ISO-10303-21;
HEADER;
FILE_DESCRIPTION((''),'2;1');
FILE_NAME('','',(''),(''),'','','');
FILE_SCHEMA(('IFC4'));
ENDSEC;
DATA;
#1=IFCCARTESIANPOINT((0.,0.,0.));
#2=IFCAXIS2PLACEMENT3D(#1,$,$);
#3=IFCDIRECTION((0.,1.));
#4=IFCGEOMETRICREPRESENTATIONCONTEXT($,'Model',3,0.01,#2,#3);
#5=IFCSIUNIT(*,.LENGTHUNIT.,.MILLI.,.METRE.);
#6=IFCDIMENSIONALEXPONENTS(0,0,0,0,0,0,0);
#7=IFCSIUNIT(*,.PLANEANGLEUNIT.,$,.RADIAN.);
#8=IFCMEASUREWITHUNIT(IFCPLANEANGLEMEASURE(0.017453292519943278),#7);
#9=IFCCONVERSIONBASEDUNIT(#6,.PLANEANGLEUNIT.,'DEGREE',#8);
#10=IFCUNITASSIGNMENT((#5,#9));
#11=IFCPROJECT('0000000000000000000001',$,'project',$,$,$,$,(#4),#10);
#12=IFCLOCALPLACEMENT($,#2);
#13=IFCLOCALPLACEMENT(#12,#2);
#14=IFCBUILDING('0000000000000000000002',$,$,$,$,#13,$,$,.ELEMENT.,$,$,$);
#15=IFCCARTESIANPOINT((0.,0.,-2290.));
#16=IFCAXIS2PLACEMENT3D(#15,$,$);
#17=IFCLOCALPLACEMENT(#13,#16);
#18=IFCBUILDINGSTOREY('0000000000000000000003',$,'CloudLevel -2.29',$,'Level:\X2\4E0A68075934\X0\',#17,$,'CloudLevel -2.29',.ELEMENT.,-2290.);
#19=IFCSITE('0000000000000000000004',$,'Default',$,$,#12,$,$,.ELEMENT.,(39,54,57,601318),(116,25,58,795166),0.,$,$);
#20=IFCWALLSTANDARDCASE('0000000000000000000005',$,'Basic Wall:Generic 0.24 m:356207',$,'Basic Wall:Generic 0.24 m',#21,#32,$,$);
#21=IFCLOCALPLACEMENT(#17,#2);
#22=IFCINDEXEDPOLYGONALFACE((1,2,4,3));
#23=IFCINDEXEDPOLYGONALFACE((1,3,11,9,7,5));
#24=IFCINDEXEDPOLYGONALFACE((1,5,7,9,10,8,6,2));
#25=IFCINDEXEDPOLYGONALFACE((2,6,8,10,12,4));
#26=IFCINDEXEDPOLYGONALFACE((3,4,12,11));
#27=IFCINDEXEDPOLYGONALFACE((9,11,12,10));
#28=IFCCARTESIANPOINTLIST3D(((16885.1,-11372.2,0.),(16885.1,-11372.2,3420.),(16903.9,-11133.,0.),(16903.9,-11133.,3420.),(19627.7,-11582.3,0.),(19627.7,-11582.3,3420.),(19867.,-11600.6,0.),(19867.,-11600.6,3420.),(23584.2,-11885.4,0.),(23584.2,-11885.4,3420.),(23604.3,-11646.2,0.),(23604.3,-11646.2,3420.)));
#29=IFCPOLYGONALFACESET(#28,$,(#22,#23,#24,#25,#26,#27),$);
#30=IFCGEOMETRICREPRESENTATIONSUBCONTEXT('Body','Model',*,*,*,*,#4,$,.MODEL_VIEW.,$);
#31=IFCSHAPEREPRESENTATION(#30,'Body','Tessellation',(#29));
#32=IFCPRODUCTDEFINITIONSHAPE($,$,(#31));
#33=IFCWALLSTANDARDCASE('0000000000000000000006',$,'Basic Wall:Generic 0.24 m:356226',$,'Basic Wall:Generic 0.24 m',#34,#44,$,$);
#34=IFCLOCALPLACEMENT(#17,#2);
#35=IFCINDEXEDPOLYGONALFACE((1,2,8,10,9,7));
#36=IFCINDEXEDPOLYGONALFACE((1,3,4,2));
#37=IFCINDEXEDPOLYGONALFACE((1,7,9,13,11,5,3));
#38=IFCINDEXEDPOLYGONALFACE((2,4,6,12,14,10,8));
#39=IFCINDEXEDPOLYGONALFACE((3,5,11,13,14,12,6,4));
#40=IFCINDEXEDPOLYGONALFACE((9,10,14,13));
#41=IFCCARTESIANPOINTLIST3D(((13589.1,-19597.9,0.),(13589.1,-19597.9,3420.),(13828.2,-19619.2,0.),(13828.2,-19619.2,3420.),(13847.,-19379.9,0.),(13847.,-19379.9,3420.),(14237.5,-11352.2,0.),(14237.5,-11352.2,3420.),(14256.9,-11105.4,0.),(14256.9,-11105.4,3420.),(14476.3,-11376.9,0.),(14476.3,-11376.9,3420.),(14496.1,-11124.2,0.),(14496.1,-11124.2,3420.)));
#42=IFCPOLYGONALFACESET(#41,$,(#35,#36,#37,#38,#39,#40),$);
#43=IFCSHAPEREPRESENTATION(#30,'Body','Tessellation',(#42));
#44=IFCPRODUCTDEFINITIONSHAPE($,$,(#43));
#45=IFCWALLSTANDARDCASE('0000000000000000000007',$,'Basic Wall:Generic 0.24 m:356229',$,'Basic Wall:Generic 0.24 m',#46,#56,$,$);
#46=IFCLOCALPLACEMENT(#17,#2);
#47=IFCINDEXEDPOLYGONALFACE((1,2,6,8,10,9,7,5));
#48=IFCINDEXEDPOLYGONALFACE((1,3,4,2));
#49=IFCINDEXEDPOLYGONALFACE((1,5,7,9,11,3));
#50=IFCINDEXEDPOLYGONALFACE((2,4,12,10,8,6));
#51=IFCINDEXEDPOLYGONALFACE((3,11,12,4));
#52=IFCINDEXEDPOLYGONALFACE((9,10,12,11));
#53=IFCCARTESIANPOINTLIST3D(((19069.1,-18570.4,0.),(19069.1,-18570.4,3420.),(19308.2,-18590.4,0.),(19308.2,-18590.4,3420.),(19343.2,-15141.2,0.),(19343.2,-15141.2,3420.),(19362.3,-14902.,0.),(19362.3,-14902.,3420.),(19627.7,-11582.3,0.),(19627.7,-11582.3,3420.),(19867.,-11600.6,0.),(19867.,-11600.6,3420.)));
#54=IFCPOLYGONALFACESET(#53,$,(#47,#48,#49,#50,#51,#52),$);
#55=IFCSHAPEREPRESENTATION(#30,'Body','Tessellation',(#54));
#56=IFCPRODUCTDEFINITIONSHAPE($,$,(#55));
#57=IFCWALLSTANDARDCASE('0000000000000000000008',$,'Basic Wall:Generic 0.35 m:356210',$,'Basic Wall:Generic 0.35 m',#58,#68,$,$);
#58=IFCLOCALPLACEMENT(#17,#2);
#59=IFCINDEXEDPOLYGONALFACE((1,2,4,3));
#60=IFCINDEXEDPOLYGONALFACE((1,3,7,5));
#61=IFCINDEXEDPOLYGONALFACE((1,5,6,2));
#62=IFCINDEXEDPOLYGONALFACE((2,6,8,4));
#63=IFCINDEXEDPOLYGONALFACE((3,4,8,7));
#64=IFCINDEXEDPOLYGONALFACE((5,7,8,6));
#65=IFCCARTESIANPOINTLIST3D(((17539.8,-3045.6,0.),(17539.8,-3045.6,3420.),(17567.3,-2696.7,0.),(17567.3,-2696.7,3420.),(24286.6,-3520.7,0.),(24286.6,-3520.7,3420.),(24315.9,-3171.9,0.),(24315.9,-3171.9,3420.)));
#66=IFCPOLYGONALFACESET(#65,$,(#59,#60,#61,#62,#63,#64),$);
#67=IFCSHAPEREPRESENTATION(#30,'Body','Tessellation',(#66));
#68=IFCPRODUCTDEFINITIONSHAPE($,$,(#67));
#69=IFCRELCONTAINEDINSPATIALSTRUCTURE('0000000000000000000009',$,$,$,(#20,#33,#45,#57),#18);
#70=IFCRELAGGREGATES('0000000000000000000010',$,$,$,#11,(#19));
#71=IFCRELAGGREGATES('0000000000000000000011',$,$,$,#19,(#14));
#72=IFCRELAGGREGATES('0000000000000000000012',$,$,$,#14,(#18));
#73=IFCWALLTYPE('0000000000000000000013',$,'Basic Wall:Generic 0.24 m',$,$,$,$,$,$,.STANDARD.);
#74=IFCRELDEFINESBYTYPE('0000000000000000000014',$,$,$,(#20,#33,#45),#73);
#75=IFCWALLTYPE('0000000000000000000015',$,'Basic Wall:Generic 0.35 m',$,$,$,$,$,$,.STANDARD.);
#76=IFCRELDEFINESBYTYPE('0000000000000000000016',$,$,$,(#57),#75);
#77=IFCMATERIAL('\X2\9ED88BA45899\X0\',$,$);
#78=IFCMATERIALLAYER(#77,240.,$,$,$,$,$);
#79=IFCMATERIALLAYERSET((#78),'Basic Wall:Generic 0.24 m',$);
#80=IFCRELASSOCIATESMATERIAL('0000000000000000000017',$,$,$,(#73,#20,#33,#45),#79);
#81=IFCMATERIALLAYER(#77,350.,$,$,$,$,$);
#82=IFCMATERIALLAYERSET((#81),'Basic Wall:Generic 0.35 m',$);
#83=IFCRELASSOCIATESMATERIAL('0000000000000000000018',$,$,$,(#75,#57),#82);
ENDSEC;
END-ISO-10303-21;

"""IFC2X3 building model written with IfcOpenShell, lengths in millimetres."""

from ifc_helpers import new_model, entity, si_unit, converted_unit, direction, frame, origin, place, context, subcontext, project, spatial, polyline, outline, extrude, material, layer, layer_set, layer_usage, type_object, element, save


model = new_model("IFC2X3")

# Units and contexts
model_context = context("Model", 3, precision=0.01, world=origin(), true_north=direction((0.0, 1.0)))
body_context = subcontext(model_context, "Body", "Model", "MODEL_VIEW")
ifc_project = project(units=[si_unit("LENGTHUNIT", "METRE", prefix="MILLI"), converted_unit("PLANEANGLEUNIT", "DEGREE", entity("IfcPlaneAngleMeasure", 0.017453292519943278), si_unit("PLANEANGLEUNIT", "RADIAN"), dimensions=[0, 0, 0, 0, 0, 0, 0])], contexts=[model_context])

# Site, building, storey
site_placement = place(None, origin())
site = spatial("IfcSite", under=ifc_project, at=site_placement, Name="Default", CompositionType="ELEMENT", RefLatitude=(39, 54, 57, 601318), RefLongitude=(116, 25, 58, 795166), RefElevation=0.0)
building_placement = place(site_placement, origin())
building = spatial("IfcBuilding", under=site, at=building_placement, CompositionType="ELEMENT")
storey_placement = place(building_placement, frame((0.0, 0.0, -2290.0)))
storey = spatial("IfcBuildingStorey", under=building, at=storey_placement, Name="CloudLevel -2.29", ObjectType="Level:上标头", LongName="CloudLevel -2.29", CompositionType="ELEMENT", Elevation=-2290.0)

# Shared definitions
ifc_material_1 = material(Name="默认墙")
ifc_layer_1 = layer(ifc_material_1, 240.0)
ifc_layer_set_1 = layer_set([ifc_layer_1], Name="Basic Wall:Generic 0.24 m")
ifc_layer_usage_1 = layer_usage(ifc_layer_set_1, "AXIS2", "NEGATIVE", 120.0)
wall_type_1 = type_object("IfcWallType", Name="Basic Wall:Generic 0.24 m", PredefinedType="STANDARD", material=ifc_layer_set_1)

# Walls
wall_1_placement = place(storey_placement, frame((16894.3, -11252.6, 0.0), z_axis=(0.0, 0.0, 1.0), x_axis=(0.997079, -0.076375, 0.0)))
element("IfcWallStandardCase", 1, at=wall_1_placement, inside=storey, type_object=wall_type_1, material=ifc_layer_usage_1, Name="Basic Wall:Generic 0.24 m:356207", ObjectType="Basic Wall:Generic 0.24 m", context=body_context, shape_type="SweptSolid", body=[
    extrude(outline(polyline([(6718.7, -120.0), (6720.5, 120.0), (0.5, 120.0), (0.0, -120.0), (2750.6, -120.0), (2990.6, -120.0), (6718.7, -120.0)])), origin(), (0.0, 0.0, 1.0), 3420.0),
])
wall_2_placement = place(storey_placement, frame((14376.5, -11114.8, 0.0), z_axis=(0.0, 0.0, 1.0), x_axis=(-0.078386, -0.996923, 0.0)))
element("IfcWallStandardCase", 2, at=wall_2_placement, inside=storey, type_object=wall_type_1, material=ifc_layer_usage_1, Name="Basic Wall:Generic 0.24 m:356226", ObjectType="Basic Wall:Generic 0.24 m", context=body_context, shape_type="SweptSolid", body=[
    extrude(outline(polyline([(8518.8, -120.0), (8521.2, 120.0), (8281.2, 120.0), (253.5, 120.0), (0.0, 120.0), (0.0, -120.0), (247.6, -120.0), (8518.8, -120.0)])), origin(), (0.0, 0.0, 1.0), 3420.0),
])
wall_3_placement = place(storey_placement, frame((19747.4, -11591.1, 0.0), z_axis=(0.0, 0.0, 1.0), x_axis=(-0.079685, -0.99682, 0.0)))
element("IfcWallStandardCase", 3, at=wall_3_placement, inside=storey, type_object=wall_type_1, material=ifc_layer_usage_1, Name="Basic Wall:Generic 0.24 m:356229", ObjectType="Basic Wall:Generic 0.24 m", context=body_context, shape_type="SweptSolid", body=[
    extrude(outline(polyline([(7011.2, -120.0), (7012.1, 120.0), (0.0, 120.0), (0.8, -120.0), (3331.0, -120.0), (3571.0, -120.0), (7011.2, -120.0)])), origin(), (0.0, 0.0, 1.0), 3420.0),
])
ifc_layer_2 = layer(ifc_material_1, 350.0)
ifc_layer_set_2 = layer_set([ifc_layer_2], Name="Basic Wall:Generic 0.35 m")
ifc_layer_usage_2 = layer_usage(ifc_layer_set_2, "AXIS2", "NEGATIVE", 175.0)
wall_type_2 = type_object("IfcWallType", Name="Basic Wall:Generic 0.35 m", PredefinedType="STANDARD", material=ifc_layer_set_2)
wall_4_placement = place(storey_placement, frame((17552.1, -2871.0, 0.0), z_axis=(0.0, 0.0, 1.0), x_axis=(0.997529, -0.07025, 0.0)))
element("IfcWallStandardCase", 4, at=wall_4_placement, inside=storey, type_object=wall_type_2, material=ifc_layer_usage_2, Name="Basic Wall:Generic 0.35 m:356210", ObjectType="Basic Wall:Generic 0.35 m", context=body_context, shape_type="SweptSolid", body=[
    extrude(outline(polyline([(6763.5, -175.0), (6768.2, 175.0), (2.9, 175.0), (0.0, -175.0), (6763.5, -175.0)])), origin(), (0.0, 0.0, 1.0), 3420.0),
])

save(model, "model.ifc")
